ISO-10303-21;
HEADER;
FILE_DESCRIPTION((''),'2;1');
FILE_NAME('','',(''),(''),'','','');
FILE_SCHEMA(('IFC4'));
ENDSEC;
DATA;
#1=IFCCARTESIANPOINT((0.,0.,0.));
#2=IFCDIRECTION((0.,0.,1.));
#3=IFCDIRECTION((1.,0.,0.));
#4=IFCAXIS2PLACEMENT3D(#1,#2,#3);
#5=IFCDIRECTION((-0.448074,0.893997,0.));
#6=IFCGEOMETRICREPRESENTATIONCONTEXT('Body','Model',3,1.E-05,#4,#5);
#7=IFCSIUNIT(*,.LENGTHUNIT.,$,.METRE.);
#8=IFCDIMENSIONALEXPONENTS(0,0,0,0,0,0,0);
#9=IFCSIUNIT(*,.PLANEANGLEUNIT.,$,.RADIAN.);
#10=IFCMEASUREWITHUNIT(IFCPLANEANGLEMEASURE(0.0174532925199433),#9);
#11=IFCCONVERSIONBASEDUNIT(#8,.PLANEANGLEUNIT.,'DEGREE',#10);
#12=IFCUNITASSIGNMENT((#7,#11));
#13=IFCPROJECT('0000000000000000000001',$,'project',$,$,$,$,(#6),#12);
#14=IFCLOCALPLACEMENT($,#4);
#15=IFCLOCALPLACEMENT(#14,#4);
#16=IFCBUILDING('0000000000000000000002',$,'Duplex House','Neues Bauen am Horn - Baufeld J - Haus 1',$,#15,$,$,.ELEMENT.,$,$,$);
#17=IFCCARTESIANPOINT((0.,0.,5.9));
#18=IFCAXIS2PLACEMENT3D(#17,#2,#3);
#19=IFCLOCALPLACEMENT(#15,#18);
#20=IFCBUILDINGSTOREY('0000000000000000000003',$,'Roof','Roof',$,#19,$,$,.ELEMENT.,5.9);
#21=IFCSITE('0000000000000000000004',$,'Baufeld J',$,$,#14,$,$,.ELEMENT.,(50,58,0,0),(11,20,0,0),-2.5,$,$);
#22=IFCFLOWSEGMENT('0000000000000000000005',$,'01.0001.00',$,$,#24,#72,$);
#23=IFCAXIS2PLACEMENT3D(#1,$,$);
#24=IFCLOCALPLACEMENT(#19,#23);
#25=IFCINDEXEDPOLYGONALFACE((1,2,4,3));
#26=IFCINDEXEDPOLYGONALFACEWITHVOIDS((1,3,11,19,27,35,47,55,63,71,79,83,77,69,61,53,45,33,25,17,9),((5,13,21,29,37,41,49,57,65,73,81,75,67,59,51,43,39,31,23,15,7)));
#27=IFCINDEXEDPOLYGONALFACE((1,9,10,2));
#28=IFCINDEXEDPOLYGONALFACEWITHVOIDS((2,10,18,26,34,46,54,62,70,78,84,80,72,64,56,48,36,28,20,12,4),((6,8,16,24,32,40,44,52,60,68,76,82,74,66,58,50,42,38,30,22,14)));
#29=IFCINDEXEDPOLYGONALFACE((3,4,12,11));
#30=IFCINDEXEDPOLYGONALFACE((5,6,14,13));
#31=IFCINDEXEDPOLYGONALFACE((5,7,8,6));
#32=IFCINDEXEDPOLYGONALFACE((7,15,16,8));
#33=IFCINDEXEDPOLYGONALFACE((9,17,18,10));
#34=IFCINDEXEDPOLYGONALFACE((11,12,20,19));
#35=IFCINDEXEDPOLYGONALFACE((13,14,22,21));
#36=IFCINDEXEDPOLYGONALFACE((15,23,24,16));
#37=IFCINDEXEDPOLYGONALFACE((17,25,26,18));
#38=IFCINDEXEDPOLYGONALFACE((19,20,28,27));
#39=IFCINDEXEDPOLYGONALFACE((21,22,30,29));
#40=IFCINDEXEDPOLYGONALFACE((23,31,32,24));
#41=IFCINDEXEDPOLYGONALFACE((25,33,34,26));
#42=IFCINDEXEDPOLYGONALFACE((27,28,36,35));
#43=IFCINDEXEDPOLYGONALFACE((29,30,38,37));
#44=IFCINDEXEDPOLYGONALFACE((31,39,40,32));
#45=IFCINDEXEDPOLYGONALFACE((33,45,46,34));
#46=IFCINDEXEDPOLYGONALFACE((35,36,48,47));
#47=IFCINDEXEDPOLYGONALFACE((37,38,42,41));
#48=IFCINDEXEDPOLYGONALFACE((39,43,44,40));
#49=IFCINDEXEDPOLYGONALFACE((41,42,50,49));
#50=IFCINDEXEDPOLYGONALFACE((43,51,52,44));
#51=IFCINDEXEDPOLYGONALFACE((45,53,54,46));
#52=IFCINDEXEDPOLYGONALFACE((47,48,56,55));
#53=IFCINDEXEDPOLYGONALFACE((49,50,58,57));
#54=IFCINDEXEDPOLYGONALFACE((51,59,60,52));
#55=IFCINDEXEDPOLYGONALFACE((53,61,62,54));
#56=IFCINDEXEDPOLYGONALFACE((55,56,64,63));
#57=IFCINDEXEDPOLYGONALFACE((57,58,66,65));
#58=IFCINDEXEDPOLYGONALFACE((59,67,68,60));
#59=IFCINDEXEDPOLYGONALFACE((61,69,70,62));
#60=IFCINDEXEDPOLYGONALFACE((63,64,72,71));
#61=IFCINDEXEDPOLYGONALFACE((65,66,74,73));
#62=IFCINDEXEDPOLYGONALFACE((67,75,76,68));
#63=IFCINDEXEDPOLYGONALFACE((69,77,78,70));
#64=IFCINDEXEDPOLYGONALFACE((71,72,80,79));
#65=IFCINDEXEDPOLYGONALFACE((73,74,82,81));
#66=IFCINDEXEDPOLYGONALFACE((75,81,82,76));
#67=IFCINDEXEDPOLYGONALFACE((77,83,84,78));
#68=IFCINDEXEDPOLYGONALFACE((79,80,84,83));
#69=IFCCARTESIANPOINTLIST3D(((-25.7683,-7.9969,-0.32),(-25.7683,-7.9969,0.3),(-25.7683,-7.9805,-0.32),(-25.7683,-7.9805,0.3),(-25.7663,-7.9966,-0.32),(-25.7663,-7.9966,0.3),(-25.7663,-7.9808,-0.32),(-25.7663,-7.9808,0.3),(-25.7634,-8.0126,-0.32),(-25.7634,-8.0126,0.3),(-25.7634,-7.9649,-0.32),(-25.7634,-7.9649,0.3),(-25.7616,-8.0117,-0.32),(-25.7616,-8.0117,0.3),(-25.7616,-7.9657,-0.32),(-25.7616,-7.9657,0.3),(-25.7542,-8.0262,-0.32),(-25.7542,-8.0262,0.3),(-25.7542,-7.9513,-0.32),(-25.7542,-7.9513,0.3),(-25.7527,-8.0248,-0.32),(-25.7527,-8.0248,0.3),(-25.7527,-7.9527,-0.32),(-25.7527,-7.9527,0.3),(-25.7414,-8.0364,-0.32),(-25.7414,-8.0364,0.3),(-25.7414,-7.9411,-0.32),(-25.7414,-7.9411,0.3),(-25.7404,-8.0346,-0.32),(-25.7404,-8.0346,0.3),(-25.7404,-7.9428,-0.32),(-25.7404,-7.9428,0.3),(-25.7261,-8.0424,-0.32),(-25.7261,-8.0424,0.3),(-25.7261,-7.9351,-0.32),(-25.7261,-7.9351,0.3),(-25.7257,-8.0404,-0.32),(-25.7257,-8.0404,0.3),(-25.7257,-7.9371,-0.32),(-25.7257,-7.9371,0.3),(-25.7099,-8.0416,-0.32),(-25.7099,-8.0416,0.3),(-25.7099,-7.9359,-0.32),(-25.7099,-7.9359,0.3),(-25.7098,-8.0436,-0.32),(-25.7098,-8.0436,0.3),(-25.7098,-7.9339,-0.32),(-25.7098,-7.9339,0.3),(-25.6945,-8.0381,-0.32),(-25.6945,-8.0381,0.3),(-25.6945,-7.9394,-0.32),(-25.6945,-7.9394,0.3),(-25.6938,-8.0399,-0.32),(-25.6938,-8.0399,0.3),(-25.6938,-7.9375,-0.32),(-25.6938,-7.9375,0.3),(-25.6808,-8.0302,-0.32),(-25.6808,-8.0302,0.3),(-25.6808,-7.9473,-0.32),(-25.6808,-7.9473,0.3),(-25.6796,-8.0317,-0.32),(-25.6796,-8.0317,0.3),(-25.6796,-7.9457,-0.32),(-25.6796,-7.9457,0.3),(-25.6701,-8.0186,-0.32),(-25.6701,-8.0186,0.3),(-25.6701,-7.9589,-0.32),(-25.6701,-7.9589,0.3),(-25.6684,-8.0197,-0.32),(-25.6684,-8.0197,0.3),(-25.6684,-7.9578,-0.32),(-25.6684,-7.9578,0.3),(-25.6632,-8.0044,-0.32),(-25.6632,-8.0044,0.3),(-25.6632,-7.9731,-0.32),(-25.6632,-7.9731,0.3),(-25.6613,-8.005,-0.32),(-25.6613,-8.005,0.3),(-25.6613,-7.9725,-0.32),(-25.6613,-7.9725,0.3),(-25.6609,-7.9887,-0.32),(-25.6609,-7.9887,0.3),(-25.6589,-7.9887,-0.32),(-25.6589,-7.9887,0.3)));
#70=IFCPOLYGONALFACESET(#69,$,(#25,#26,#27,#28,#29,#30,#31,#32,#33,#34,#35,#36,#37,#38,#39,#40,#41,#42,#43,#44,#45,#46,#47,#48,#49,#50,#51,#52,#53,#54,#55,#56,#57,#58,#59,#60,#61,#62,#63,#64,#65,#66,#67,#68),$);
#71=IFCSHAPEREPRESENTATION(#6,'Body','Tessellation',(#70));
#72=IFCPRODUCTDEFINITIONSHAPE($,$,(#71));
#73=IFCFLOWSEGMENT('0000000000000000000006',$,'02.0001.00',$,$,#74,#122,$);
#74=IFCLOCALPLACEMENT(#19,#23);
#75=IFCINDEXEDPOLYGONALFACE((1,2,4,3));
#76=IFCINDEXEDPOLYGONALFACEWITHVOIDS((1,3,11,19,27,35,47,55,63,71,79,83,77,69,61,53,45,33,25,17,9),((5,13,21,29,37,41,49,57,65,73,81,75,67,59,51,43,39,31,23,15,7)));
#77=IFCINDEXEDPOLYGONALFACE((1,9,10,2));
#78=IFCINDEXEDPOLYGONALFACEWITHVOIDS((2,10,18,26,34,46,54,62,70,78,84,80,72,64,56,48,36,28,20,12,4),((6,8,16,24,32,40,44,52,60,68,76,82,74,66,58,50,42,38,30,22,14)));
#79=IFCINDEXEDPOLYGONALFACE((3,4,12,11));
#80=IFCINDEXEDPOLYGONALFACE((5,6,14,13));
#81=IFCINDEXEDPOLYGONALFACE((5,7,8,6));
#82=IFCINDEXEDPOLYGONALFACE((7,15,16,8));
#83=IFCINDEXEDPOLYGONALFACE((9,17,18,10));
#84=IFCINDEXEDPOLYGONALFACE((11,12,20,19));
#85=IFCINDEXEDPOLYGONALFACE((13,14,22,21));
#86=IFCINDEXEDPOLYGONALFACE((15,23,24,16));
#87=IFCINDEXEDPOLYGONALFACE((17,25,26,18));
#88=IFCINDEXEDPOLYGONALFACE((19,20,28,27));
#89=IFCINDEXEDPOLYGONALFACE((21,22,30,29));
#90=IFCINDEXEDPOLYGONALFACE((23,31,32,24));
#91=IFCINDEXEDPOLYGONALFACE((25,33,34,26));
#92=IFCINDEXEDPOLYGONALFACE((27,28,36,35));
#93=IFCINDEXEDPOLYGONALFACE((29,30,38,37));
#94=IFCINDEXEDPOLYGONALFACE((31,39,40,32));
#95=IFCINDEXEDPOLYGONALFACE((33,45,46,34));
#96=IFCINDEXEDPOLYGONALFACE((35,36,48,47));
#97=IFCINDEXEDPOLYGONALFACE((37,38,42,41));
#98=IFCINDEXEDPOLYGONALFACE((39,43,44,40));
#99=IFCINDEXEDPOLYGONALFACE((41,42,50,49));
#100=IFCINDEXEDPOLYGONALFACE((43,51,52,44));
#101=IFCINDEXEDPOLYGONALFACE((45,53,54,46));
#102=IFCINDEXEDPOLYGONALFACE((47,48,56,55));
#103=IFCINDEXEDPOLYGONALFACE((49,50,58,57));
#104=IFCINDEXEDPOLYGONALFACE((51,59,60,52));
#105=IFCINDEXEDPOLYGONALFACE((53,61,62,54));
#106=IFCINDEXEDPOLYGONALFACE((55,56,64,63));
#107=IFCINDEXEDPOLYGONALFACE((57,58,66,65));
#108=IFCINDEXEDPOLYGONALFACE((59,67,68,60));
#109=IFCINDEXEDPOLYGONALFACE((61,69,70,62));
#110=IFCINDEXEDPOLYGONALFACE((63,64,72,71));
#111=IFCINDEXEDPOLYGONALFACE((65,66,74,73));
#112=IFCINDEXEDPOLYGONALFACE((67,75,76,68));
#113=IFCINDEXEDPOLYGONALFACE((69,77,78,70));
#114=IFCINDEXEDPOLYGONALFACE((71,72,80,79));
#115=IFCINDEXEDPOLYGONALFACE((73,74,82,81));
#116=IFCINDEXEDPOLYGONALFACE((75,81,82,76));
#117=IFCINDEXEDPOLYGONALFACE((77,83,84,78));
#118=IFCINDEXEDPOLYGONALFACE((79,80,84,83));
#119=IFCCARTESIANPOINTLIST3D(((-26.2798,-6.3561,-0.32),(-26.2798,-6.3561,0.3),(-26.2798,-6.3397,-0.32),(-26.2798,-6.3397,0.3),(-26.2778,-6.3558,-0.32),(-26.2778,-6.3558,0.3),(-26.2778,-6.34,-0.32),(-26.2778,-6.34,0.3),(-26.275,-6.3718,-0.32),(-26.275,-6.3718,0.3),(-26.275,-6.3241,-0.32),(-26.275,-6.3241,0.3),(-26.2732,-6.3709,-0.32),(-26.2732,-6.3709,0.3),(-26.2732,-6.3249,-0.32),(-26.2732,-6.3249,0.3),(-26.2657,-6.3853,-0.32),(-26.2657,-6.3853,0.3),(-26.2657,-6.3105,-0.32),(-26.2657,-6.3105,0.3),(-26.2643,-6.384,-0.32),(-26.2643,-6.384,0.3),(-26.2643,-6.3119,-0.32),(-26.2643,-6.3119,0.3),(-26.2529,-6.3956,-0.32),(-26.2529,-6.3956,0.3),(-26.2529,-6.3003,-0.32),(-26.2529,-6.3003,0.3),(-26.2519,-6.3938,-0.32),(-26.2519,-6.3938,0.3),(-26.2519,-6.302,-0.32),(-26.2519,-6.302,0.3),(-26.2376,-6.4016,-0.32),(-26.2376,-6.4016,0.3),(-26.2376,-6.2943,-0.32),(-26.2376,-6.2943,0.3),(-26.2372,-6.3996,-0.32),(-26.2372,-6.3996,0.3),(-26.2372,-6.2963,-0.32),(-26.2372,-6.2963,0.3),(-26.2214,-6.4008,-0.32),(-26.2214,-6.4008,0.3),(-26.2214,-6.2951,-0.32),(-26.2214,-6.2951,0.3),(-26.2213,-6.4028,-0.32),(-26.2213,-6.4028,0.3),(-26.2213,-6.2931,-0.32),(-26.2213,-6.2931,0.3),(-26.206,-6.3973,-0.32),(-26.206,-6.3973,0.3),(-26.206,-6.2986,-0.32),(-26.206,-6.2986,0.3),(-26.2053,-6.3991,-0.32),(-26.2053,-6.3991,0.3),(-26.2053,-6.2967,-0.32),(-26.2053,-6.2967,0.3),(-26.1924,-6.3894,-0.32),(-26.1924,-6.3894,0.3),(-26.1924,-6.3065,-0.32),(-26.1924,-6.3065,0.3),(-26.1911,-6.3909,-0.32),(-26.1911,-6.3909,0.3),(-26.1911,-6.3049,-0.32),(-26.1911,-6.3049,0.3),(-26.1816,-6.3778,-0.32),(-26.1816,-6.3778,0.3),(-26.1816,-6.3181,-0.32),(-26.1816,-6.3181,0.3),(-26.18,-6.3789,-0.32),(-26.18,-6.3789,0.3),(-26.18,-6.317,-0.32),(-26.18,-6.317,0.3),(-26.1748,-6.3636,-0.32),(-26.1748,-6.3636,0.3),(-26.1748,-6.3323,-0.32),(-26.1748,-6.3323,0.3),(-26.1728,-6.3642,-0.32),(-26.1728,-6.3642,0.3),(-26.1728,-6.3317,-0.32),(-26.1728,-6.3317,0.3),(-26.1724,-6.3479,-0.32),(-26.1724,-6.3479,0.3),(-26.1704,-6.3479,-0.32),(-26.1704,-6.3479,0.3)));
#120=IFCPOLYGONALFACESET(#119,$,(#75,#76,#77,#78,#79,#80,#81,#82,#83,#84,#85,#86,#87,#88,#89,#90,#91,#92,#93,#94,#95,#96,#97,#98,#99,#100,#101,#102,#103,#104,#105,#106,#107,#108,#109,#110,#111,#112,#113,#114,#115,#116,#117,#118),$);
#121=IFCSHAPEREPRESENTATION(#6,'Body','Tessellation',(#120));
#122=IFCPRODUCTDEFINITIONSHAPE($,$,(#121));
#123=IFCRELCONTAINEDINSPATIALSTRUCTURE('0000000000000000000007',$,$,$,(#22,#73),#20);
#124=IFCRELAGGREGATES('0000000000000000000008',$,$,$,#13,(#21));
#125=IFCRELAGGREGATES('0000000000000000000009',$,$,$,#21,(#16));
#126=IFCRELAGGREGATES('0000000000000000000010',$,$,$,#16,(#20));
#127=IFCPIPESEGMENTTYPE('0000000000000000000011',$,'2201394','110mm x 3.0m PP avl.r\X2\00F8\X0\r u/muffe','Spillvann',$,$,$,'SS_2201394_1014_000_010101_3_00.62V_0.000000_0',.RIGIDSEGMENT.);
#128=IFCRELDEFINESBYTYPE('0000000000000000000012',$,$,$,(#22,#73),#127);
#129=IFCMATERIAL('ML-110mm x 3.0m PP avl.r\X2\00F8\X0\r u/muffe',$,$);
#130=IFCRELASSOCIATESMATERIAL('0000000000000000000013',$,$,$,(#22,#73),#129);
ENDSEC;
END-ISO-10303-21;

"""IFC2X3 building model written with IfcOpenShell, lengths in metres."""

from ifc_helpers import new_model, entity, si_unit, converted_unit, direction, frame, origin_with_axes, origin_2d_with_axis, place, context, project, spatial, hollow_circle, extrude, material, type_object, element, save


model = new_model("IFC2X3")

# Units and contexts
model_context = context("Model", 3, precision=1e-05, world=origin_with_axes(), true_north=direction((-0.448074, 0.893997, 0.0)), identifier="Body")
ifc_project = project(units=[si_unit("LENGTHUNIT", "METRE"), converted_unit("PLANEANGLEUNIT", "DEGREE", entity("IfcPlaneAngleMeasure", 0.0174532925199433), si_unit("PLANEANGLEUNIT", "RADIAN"), dimensions=[0, 0, 0, 0, 0, 0, 0])], contexts=[model_context])

# Site, building, storey
site_placement = place(None, origin_with_axes())
site = spatial("IfcSite", under=ifc_project, at=site_placement, Name="Baufeld J", CompositionType="ELEMENT", RefLatitude=(50, 58, 0, 0), RefLongitude=(11, 20, 0, 0), RefElevation=-2.5)
building_placement = place(site_placement, origin_with_axes())
building = spatial("IfcBuilding", under=site, at=building_placement, Name="Duplex House", Description="Neues Bauen am Horn - Baufeld J - Haus 1", CompositionType="ELEMENT")
storey_placement = place(building_placement, frame((0.0, 0.0, 5.9), z_axis=(0.0, 0.0, 1.0), x_axis=(1.0, 0.0, 0.0)))
storey = spatial("IfcBuildingStorey", under=building, at=storey_placement, Name="Roof", Description="Roof", CompositionType="ELEMENT", Elevation=5.9)

# Flow segments
ifc_material = material(Name="ML-110mm x 3.0m PP avl.rør u/muffe")
pipe_segment_type = type_object("IfcPipeSegmentType", Name="2201394", Description="110mm x 3.0m PP avl.rør u/muffe", ApplicableOccurrence="Spillvann", ElementType="SS_2201394_1014_000_010101_3_00.62V_0.000000_0", PredefinedType="RIGIDSEGMENT")
for number, where, z_axis, x_axis, name in (
    (1, (-25.7139, -7.9887, 0.3), (-1.0, 0.0, 0.0), (0.0, 0.0, -1.0), "01.0001.00"),
    (2, (-26.2254, -6.3479, 0.3), (-1.0, 0.0, 0.0), (0.0, 0.0, -1.0), "02.0001.00"),
):
    element("IfcFlowSegment", number, at=place(storey_placement, frame(where, z_axis=z_axis, x_axis=x_axis)), inside=storey, type_object=pipe_segment_type, material=ifc_material, Name=name, context=model_context, shape_type="SweptSolid", body=[
        extrude(hollow_circle(Radius=0.055, WallThickness=0.002, at=origin_2d_with_axis()), frame((0.0, 0.0, 0.0), z_axis=(1.0, 0.0, 0.0), x_axis=(0.0, 0.0, -1.0)), (0.0, 0.0, 1.0), 0.62),
    ])

save(model, "model.ifc")
